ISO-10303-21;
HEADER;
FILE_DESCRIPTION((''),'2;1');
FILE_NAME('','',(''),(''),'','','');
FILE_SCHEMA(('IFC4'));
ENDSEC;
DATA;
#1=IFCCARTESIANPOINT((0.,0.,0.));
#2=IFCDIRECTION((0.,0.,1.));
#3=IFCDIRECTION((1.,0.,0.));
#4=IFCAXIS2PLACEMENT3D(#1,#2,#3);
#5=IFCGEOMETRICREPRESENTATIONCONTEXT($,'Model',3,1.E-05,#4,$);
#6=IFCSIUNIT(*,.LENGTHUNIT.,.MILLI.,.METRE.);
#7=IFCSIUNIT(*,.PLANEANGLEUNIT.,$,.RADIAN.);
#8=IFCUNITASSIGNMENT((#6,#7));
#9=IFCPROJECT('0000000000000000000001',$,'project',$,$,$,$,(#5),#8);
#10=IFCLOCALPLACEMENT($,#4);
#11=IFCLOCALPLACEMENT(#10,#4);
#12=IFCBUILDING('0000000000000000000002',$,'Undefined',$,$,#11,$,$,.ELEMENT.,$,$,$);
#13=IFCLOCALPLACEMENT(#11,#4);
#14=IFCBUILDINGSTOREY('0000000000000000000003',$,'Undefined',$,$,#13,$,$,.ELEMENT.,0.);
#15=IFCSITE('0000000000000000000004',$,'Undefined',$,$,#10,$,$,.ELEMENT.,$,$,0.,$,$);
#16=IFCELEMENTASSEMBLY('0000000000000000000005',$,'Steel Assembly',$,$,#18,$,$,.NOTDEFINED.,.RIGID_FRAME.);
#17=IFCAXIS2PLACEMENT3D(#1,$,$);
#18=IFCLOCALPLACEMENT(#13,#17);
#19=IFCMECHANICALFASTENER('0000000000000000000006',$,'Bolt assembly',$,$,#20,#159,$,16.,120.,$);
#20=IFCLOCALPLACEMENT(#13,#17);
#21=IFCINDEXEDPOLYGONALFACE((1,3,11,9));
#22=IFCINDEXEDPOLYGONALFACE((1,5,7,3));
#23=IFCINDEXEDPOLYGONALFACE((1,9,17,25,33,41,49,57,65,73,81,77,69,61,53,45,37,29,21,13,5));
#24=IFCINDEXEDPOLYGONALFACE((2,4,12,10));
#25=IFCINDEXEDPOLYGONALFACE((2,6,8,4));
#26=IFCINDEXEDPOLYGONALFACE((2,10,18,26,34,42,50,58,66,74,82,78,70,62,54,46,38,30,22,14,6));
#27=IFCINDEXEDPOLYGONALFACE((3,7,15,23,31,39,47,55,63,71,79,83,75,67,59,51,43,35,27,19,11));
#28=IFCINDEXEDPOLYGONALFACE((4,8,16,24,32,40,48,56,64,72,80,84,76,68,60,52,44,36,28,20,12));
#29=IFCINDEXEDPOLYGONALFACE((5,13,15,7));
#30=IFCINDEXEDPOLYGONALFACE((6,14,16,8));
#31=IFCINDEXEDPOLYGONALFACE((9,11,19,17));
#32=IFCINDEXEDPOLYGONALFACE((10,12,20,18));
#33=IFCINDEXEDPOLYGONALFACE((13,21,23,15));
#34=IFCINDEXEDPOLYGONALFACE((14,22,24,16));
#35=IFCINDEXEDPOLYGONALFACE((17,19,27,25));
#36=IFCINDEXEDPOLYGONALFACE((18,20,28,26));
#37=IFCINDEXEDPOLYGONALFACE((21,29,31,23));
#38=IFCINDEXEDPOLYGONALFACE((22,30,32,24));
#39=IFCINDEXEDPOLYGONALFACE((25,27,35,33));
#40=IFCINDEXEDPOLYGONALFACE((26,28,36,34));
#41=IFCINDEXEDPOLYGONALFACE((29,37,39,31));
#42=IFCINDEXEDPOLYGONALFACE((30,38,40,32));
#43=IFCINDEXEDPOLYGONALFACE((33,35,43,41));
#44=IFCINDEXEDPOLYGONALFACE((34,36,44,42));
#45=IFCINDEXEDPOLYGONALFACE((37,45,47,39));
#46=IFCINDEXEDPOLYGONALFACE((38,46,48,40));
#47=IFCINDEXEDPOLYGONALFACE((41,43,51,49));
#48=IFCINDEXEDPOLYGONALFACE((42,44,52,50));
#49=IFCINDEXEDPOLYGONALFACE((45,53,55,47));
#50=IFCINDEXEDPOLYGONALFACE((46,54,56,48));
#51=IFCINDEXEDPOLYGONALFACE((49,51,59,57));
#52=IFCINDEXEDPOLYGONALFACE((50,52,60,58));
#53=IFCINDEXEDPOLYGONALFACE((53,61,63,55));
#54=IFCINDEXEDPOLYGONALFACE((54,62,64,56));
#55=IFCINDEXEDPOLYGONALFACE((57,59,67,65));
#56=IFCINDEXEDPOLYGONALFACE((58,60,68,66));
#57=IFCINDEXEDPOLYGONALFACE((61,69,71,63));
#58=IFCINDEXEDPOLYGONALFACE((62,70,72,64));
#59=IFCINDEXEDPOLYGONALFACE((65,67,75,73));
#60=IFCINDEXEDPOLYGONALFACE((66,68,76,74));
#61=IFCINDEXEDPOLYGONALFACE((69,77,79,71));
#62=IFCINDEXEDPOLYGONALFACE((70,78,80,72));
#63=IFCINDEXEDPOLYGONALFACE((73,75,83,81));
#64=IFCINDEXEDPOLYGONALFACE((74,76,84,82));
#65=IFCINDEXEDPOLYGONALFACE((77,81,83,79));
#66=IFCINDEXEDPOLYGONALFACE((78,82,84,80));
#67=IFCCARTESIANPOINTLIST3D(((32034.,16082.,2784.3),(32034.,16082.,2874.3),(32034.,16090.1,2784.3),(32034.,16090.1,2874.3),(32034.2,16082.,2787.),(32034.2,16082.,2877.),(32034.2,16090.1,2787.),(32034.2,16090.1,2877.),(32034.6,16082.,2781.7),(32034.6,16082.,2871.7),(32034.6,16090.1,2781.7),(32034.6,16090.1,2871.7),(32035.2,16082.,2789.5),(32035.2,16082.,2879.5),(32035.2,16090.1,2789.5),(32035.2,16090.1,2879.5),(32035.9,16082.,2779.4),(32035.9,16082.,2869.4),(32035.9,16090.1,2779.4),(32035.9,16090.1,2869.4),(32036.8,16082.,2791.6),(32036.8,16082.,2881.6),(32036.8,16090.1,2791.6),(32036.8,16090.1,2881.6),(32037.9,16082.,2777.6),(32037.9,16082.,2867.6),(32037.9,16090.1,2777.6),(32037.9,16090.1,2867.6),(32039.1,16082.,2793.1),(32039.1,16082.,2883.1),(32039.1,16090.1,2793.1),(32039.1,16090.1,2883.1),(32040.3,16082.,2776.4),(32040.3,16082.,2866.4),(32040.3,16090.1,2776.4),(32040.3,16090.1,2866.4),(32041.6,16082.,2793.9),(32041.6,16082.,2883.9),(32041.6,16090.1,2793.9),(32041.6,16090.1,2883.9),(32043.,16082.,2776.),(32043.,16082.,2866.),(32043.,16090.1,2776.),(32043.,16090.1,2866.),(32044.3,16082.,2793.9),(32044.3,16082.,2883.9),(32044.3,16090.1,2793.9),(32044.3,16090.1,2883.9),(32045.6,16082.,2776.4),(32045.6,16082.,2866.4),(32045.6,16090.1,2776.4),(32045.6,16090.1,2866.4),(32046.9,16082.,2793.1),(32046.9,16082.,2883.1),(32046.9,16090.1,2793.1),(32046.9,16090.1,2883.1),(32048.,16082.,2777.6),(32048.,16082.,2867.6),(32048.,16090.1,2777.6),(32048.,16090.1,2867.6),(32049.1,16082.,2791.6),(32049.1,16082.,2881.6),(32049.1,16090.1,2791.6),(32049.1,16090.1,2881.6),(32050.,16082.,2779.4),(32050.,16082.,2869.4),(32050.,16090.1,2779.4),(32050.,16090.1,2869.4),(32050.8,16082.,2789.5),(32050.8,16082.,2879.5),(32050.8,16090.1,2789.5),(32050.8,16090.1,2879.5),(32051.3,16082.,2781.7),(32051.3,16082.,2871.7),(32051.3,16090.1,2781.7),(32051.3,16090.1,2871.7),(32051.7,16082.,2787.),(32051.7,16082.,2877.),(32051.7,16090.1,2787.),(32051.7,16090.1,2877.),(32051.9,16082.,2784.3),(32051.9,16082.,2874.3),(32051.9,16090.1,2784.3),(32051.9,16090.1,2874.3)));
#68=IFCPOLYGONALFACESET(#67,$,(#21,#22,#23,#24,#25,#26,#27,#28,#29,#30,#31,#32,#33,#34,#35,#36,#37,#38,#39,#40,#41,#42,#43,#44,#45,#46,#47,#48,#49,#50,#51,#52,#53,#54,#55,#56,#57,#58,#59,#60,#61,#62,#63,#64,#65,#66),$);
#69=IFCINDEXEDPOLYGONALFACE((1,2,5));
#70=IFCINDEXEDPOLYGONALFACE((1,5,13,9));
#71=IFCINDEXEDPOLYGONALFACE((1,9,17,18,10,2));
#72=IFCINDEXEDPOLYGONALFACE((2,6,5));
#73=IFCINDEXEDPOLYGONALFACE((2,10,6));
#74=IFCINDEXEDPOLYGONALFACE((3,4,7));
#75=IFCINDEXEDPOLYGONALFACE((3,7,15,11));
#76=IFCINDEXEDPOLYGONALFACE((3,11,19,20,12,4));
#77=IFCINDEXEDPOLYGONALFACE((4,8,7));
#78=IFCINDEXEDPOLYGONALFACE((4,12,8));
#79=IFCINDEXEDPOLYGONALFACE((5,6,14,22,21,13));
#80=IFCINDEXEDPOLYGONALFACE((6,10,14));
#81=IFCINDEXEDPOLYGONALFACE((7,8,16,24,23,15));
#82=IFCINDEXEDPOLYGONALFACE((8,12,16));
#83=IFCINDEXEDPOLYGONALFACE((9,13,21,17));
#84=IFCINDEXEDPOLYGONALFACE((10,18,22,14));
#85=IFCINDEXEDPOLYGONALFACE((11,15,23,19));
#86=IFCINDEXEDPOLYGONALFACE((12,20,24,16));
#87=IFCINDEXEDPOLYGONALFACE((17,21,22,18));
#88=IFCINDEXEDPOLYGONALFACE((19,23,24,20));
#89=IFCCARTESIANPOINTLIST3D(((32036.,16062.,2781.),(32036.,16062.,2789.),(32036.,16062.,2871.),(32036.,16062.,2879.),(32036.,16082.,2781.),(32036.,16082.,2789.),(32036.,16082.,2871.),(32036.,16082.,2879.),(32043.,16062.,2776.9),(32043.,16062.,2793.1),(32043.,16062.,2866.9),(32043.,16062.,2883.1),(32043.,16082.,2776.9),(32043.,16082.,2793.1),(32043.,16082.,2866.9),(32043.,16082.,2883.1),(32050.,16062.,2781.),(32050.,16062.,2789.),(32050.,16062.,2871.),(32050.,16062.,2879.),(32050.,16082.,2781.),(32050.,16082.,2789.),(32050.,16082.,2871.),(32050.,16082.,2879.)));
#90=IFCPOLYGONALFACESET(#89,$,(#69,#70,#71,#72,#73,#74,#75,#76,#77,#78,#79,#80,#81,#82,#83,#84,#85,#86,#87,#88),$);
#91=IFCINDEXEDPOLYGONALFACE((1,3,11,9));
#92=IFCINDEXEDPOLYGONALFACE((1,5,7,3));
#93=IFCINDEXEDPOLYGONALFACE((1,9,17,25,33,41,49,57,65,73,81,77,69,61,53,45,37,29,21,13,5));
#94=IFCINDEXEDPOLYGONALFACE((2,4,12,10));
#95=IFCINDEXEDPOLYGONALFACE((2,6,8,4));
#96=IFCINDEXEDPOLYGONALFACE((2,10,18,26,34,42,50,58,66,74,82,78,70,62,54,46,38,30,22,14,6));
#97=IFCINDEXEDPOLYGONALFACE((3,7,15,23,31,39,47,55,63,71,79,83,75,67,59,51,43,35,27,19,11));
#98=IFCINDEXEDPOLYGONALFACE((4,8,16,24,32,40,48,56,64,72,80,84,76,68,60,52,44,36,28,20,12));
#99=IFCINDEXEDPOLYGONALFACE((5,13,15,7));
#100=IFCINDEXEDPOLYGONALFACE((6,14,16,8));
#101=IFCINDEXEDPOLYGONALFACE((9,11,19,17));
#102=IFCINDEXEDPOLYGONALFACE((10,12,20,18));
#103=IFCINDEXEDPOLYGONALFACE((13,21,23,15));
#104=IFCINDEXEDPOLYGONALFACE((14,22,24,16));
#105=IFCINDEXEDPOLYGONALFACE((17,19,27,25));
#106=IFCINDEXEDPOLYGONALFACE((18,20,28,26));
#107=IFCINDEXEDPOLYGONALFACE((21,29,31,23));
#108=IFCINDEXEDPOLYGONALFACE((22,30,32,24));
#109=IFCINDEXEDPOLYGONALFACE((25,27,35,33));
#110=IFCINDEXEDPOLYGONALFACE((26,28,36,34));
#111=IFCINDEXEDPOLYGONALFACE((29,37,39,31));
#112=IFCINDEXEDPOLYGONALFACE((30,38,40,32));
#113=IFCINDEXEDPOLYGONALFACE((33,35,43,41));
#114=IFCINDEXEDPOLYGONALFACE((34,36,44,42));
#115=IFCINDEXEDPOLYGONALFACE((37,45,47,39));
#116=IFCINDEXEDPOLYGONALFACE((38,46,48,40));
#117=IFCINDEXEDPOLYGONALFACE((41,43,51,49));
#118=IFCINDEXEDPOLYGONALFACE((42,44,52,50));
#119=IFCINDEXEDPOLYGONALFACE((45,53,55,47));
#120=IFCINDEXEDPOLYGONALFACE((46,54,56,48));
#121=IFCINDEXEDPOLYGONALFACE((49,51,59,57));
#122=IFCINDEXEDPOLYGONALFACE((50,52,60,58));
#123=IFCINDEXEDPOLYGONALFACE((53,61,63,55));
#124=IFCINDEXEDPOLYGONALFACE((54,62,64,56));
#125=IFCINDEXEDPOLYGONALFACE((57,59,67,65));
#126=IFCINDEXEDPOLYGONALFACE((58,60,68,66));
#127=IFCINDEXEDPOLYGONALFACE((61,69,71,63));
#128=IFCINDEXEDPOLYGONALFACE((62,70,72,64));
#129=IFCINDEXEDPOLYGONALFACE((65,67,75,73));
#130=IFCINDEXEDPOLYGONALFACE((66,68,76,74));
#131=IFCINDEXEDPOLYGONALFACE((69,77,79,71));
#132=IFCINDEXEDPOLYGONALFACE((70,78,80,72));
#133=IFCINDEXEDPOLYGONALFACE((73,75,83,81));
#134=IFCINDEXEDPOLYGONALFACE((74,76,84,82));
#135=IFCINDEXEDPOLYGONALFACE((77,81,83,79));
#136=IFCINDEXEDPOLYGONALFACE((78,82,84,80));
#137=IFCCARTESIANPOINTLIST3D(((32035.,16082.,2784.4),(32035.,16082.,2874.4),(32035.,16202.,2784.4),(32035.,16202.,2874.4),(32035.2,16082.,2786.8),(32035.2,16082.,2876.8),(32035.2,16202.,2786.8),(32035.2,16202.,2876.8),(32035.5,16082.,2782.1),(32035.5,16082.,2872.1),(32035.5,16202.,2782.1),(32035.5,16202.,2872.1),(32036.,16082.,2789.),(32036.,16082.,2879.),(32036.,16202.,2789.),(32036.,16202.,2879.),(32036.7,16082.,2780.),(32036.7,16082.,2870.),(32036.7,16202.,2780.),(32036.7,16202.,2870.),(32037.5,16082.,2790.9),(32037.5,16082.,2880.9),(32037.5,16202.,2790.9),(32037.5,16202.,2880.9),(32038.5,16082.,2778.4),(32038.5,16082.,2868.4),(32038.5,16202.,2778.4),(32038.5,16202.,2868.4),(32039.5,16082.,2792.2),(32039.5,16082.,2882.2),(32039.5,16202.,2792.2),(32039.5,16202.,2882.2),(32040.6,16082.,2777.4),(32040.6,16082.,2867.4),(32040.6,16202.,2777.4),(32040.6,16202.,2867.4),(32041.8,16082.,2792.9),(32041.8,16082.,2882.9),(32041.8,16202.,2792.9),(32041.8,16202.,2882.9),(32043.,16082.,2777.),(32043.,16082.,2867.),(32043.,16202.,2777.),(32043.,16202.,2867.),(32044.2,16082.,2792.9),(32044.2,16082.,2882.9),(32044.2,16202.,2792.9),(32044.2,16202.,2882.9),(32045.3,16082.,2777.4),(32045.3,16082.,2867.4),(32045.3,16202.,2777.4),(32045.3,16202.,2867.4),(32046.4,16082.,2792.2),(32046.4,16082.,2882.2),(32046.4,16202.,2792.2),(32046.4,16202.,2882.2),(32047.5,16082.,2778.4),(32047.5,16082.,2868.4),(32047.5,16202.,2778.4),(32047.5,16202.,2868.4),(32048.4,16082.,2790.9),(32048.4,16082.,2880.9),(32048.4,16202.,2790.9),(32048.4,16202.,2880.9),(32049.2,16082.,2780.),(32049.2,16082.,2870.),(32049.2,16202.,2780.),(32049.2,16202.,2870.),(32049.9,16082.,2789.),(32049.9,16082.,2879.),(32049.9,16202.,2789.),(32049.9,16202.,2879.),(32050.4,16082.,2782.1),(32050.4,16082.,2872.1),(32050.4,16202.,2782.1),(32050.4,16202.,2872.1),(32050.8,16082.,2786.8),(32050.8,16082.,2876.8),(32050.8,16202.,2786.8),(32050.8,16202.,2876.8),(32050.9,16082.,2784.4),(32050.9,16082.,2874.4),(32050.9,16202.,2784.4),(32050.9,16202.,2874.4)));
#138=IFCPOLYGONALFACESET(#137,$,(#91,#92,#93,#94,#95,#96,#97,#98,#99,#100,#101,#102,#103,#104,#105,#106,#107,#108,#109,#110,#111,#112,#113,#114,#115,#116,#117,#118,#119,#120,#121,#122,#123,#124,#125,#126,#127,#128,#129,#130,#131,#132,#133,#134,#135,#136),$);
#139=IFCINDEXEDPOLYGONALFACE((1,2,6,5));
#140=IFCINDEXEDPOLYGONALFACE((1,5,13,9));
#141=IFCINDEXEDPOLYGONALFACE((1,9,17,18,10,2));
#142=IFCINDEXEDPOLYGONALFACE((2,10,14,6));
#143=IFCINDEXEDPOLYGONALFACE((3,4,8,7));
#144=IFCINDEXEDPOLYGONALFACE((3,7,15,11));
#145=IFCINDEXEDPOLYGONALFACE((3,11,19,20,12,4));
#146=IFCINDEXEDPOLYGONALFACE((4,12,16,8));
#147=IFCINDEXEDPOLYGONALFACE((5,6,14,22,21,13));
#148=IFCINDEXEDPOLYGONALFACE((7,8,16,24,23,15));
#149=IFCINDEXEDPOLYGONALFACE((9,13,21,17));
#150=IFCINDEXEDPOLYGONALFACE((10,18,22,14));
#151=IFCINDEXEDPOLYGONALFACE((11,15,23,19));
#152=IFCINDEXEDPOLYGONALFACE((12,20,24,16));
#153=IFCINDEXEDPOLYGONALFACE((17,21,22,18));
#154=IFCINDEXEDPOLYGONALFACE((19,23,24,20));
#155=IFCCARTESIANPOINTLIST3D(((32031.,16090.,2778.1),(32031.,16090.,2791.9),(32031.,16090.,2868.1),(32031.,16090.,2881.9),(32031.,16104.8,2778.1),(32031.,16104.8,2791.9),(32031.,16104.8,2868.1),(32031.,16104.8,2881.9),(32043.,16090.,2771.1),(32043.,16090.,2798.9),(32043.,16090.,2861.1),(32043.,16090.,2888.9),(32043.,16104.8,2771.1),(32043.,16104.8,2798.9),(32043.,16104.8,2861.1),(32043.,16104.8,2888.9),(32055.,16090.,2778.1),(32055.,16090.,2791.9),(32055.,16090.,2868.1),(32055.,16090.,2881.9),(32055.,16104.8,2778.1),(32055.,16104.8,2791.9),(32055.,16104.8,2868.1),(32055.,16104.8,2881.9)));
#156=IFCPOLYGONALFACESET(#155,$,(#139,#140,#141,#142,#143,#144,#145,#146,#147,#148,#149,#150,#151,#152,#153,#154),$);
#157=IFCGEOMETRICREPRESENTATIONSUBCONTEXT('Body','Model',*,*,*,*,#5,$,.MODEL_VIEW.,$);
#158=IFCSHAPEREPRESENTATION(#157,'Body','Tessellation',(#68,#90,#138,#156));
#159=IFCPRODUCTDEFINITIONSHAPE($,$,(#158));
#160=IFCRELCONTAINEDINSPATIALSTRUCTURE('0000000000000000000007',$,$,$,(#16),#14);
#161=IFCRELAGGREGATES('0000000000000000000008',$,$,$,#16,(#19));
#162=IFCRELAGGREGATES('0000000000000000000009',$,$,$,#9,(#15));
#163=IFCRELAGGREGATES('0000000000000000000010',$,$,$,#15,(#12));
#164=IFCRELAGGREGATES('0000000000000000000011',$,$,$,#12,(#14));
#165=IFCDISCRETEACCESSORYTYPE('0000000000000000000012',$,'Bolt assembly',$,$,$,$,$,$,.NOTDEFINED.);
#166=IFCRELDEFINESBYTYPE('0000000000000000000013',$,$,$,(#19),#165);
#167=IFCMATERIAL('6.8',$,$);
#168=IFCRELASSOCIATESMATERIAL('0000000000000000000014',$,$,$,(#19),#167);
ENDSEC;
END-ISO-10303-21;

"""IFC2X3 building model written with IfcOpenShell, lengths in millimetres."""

from ifc_helpers import new_model, si_unit, frame, origin_with_axes, origin_2d_with_axis, place, context, subcontext, project, spatial, polyline, circle, outline, extrude, source, transform, mapped, material, type_object, element, aggregate, save


model = new_model("IFC2X3")

# Units and contexts
model_context = context("Model", 3, precision=1e-05, world=origin_with_axes())
body_context = subcontext(model_context, "Body", "Model", "MODEL_VIEW")
ifc_project = project(units=[si_unit("LENGTHUNIT", "METRE", prefix="MILLI"), si_unit("PLANEANGLEUNIT", "RADIAN")], contexts=[model_context])

# Site, building, storey
site_placement = place(None, origin_with_axes())
site = spatial("IfcSite", under=ifc_project, at=site_placement, Name="Undefined", CompositionType="ELEMENT", RefElevation=0.0)
building_placement = place(site_placement, origin_with_axes())
building = spatial("IfcBuilding", under=site, at=building_placement, Name="Undefined", CompositionType="ELEMENT")
storey_placement = place(building_placement, origin_with_axes())
storey = spatial("IfcBuildingStorey", under=building, at=storey_placement, Name="Undefined", CompositionType="ELEMENT", Elevation=0.0)

# Shared definitions
ifc_material_1 = material(Name="6.8")
discrete_accessory_type_1 = type_object("IfcDiscreteAccessoryType", Name="Bolt assembly")
shared_shape_1 = source(origin_with_axes(), body_context, "Body", "SweptSolid", [
    extrude(circle(Radius=9.0, at=origin_2d_with_axis()), frame((0.0, -8.0, 0.0), z_axis=(0.0, 1.0, 0.0), x_axis=(1.0, 0.0, 0.0)), (0.0, 0.0, 1.0), 8.1),
    extrude(outline(polyline([(8.1, 0.0), (4.0, 7.0), (-4.0, 7.0), (-8.1, 0.0), (-4.0, -7.0), (4.0, -7.0), (8.1, 0.0)])), frame((0.0, -28.0, 0.0), z_axis=(0.0, 1.0, 0.0), x_axis=(1.0, 0.0, 0.0)), (0.0, 0.0, 1.0), 20.0),
    extrude(circle(Radius=8.0, at=origin_2d_with_axis()), frame((0.0, -8.0, 0.0), z_axis=(0.0, 1.0, 0.0), x_axis=(1.0, 0.0, 0.0)), (0.0, 0.0, 1.0), 120.0),
    extrude(outline(polyline([(13.9, 0.0), (6.9, 12.0), (-6.9, 12.0), (-13.9, 0.0), (-6.9, -12.0), (6.9, -12.0), (13.9, 0.0)])), frame((0.0, 0.0, 0.0), z_axis=(0.0, 1.0, 0.0), x_axis=(1.0, 0.0, 0.0)), (0.0, 0.0, 1.0), 14.8),
])

# Element assembly, mechanical fastener
assembly_1_placement = place(storey_placement, origin_with_axes())
assembly_1 = element("IfcElementAssembly", 1, at=assembly_1_placement, inside=storey, Name="Steel Assembly", AssemblyPlace="NOTDEFINED", PredefinedType="RIGID_FRAME")
mechanical_fastener_1_placement = place(assembly_1_placement, frame((32043.0, 16090.0, 2875.0), z_axis=(1.0, 0.0, 0.0), x_axis=(0.0, 0.0, -1.0)))
mechanical_fastener_1 = element("IfcMechanicalFastener", 2, at=mechanical_fastener_1_placement, type_object=discrete_accessory_type_1, material=ifc_material_1, Name="Bolt assembly", NominalDiameter=16.0, NominalLength=120.0, context=body_context, shape_type="MappedRepresentation", body=[
    mapped(shared_shape_1, transform((0.0, 0.0, 0.0))),
    mapped(shared_shape_1, transform((90.0, 0.0, 0.0))),
])

aggregate(assembly_1, [mechanical_fastener_1])

save(model, "model.ifc")
